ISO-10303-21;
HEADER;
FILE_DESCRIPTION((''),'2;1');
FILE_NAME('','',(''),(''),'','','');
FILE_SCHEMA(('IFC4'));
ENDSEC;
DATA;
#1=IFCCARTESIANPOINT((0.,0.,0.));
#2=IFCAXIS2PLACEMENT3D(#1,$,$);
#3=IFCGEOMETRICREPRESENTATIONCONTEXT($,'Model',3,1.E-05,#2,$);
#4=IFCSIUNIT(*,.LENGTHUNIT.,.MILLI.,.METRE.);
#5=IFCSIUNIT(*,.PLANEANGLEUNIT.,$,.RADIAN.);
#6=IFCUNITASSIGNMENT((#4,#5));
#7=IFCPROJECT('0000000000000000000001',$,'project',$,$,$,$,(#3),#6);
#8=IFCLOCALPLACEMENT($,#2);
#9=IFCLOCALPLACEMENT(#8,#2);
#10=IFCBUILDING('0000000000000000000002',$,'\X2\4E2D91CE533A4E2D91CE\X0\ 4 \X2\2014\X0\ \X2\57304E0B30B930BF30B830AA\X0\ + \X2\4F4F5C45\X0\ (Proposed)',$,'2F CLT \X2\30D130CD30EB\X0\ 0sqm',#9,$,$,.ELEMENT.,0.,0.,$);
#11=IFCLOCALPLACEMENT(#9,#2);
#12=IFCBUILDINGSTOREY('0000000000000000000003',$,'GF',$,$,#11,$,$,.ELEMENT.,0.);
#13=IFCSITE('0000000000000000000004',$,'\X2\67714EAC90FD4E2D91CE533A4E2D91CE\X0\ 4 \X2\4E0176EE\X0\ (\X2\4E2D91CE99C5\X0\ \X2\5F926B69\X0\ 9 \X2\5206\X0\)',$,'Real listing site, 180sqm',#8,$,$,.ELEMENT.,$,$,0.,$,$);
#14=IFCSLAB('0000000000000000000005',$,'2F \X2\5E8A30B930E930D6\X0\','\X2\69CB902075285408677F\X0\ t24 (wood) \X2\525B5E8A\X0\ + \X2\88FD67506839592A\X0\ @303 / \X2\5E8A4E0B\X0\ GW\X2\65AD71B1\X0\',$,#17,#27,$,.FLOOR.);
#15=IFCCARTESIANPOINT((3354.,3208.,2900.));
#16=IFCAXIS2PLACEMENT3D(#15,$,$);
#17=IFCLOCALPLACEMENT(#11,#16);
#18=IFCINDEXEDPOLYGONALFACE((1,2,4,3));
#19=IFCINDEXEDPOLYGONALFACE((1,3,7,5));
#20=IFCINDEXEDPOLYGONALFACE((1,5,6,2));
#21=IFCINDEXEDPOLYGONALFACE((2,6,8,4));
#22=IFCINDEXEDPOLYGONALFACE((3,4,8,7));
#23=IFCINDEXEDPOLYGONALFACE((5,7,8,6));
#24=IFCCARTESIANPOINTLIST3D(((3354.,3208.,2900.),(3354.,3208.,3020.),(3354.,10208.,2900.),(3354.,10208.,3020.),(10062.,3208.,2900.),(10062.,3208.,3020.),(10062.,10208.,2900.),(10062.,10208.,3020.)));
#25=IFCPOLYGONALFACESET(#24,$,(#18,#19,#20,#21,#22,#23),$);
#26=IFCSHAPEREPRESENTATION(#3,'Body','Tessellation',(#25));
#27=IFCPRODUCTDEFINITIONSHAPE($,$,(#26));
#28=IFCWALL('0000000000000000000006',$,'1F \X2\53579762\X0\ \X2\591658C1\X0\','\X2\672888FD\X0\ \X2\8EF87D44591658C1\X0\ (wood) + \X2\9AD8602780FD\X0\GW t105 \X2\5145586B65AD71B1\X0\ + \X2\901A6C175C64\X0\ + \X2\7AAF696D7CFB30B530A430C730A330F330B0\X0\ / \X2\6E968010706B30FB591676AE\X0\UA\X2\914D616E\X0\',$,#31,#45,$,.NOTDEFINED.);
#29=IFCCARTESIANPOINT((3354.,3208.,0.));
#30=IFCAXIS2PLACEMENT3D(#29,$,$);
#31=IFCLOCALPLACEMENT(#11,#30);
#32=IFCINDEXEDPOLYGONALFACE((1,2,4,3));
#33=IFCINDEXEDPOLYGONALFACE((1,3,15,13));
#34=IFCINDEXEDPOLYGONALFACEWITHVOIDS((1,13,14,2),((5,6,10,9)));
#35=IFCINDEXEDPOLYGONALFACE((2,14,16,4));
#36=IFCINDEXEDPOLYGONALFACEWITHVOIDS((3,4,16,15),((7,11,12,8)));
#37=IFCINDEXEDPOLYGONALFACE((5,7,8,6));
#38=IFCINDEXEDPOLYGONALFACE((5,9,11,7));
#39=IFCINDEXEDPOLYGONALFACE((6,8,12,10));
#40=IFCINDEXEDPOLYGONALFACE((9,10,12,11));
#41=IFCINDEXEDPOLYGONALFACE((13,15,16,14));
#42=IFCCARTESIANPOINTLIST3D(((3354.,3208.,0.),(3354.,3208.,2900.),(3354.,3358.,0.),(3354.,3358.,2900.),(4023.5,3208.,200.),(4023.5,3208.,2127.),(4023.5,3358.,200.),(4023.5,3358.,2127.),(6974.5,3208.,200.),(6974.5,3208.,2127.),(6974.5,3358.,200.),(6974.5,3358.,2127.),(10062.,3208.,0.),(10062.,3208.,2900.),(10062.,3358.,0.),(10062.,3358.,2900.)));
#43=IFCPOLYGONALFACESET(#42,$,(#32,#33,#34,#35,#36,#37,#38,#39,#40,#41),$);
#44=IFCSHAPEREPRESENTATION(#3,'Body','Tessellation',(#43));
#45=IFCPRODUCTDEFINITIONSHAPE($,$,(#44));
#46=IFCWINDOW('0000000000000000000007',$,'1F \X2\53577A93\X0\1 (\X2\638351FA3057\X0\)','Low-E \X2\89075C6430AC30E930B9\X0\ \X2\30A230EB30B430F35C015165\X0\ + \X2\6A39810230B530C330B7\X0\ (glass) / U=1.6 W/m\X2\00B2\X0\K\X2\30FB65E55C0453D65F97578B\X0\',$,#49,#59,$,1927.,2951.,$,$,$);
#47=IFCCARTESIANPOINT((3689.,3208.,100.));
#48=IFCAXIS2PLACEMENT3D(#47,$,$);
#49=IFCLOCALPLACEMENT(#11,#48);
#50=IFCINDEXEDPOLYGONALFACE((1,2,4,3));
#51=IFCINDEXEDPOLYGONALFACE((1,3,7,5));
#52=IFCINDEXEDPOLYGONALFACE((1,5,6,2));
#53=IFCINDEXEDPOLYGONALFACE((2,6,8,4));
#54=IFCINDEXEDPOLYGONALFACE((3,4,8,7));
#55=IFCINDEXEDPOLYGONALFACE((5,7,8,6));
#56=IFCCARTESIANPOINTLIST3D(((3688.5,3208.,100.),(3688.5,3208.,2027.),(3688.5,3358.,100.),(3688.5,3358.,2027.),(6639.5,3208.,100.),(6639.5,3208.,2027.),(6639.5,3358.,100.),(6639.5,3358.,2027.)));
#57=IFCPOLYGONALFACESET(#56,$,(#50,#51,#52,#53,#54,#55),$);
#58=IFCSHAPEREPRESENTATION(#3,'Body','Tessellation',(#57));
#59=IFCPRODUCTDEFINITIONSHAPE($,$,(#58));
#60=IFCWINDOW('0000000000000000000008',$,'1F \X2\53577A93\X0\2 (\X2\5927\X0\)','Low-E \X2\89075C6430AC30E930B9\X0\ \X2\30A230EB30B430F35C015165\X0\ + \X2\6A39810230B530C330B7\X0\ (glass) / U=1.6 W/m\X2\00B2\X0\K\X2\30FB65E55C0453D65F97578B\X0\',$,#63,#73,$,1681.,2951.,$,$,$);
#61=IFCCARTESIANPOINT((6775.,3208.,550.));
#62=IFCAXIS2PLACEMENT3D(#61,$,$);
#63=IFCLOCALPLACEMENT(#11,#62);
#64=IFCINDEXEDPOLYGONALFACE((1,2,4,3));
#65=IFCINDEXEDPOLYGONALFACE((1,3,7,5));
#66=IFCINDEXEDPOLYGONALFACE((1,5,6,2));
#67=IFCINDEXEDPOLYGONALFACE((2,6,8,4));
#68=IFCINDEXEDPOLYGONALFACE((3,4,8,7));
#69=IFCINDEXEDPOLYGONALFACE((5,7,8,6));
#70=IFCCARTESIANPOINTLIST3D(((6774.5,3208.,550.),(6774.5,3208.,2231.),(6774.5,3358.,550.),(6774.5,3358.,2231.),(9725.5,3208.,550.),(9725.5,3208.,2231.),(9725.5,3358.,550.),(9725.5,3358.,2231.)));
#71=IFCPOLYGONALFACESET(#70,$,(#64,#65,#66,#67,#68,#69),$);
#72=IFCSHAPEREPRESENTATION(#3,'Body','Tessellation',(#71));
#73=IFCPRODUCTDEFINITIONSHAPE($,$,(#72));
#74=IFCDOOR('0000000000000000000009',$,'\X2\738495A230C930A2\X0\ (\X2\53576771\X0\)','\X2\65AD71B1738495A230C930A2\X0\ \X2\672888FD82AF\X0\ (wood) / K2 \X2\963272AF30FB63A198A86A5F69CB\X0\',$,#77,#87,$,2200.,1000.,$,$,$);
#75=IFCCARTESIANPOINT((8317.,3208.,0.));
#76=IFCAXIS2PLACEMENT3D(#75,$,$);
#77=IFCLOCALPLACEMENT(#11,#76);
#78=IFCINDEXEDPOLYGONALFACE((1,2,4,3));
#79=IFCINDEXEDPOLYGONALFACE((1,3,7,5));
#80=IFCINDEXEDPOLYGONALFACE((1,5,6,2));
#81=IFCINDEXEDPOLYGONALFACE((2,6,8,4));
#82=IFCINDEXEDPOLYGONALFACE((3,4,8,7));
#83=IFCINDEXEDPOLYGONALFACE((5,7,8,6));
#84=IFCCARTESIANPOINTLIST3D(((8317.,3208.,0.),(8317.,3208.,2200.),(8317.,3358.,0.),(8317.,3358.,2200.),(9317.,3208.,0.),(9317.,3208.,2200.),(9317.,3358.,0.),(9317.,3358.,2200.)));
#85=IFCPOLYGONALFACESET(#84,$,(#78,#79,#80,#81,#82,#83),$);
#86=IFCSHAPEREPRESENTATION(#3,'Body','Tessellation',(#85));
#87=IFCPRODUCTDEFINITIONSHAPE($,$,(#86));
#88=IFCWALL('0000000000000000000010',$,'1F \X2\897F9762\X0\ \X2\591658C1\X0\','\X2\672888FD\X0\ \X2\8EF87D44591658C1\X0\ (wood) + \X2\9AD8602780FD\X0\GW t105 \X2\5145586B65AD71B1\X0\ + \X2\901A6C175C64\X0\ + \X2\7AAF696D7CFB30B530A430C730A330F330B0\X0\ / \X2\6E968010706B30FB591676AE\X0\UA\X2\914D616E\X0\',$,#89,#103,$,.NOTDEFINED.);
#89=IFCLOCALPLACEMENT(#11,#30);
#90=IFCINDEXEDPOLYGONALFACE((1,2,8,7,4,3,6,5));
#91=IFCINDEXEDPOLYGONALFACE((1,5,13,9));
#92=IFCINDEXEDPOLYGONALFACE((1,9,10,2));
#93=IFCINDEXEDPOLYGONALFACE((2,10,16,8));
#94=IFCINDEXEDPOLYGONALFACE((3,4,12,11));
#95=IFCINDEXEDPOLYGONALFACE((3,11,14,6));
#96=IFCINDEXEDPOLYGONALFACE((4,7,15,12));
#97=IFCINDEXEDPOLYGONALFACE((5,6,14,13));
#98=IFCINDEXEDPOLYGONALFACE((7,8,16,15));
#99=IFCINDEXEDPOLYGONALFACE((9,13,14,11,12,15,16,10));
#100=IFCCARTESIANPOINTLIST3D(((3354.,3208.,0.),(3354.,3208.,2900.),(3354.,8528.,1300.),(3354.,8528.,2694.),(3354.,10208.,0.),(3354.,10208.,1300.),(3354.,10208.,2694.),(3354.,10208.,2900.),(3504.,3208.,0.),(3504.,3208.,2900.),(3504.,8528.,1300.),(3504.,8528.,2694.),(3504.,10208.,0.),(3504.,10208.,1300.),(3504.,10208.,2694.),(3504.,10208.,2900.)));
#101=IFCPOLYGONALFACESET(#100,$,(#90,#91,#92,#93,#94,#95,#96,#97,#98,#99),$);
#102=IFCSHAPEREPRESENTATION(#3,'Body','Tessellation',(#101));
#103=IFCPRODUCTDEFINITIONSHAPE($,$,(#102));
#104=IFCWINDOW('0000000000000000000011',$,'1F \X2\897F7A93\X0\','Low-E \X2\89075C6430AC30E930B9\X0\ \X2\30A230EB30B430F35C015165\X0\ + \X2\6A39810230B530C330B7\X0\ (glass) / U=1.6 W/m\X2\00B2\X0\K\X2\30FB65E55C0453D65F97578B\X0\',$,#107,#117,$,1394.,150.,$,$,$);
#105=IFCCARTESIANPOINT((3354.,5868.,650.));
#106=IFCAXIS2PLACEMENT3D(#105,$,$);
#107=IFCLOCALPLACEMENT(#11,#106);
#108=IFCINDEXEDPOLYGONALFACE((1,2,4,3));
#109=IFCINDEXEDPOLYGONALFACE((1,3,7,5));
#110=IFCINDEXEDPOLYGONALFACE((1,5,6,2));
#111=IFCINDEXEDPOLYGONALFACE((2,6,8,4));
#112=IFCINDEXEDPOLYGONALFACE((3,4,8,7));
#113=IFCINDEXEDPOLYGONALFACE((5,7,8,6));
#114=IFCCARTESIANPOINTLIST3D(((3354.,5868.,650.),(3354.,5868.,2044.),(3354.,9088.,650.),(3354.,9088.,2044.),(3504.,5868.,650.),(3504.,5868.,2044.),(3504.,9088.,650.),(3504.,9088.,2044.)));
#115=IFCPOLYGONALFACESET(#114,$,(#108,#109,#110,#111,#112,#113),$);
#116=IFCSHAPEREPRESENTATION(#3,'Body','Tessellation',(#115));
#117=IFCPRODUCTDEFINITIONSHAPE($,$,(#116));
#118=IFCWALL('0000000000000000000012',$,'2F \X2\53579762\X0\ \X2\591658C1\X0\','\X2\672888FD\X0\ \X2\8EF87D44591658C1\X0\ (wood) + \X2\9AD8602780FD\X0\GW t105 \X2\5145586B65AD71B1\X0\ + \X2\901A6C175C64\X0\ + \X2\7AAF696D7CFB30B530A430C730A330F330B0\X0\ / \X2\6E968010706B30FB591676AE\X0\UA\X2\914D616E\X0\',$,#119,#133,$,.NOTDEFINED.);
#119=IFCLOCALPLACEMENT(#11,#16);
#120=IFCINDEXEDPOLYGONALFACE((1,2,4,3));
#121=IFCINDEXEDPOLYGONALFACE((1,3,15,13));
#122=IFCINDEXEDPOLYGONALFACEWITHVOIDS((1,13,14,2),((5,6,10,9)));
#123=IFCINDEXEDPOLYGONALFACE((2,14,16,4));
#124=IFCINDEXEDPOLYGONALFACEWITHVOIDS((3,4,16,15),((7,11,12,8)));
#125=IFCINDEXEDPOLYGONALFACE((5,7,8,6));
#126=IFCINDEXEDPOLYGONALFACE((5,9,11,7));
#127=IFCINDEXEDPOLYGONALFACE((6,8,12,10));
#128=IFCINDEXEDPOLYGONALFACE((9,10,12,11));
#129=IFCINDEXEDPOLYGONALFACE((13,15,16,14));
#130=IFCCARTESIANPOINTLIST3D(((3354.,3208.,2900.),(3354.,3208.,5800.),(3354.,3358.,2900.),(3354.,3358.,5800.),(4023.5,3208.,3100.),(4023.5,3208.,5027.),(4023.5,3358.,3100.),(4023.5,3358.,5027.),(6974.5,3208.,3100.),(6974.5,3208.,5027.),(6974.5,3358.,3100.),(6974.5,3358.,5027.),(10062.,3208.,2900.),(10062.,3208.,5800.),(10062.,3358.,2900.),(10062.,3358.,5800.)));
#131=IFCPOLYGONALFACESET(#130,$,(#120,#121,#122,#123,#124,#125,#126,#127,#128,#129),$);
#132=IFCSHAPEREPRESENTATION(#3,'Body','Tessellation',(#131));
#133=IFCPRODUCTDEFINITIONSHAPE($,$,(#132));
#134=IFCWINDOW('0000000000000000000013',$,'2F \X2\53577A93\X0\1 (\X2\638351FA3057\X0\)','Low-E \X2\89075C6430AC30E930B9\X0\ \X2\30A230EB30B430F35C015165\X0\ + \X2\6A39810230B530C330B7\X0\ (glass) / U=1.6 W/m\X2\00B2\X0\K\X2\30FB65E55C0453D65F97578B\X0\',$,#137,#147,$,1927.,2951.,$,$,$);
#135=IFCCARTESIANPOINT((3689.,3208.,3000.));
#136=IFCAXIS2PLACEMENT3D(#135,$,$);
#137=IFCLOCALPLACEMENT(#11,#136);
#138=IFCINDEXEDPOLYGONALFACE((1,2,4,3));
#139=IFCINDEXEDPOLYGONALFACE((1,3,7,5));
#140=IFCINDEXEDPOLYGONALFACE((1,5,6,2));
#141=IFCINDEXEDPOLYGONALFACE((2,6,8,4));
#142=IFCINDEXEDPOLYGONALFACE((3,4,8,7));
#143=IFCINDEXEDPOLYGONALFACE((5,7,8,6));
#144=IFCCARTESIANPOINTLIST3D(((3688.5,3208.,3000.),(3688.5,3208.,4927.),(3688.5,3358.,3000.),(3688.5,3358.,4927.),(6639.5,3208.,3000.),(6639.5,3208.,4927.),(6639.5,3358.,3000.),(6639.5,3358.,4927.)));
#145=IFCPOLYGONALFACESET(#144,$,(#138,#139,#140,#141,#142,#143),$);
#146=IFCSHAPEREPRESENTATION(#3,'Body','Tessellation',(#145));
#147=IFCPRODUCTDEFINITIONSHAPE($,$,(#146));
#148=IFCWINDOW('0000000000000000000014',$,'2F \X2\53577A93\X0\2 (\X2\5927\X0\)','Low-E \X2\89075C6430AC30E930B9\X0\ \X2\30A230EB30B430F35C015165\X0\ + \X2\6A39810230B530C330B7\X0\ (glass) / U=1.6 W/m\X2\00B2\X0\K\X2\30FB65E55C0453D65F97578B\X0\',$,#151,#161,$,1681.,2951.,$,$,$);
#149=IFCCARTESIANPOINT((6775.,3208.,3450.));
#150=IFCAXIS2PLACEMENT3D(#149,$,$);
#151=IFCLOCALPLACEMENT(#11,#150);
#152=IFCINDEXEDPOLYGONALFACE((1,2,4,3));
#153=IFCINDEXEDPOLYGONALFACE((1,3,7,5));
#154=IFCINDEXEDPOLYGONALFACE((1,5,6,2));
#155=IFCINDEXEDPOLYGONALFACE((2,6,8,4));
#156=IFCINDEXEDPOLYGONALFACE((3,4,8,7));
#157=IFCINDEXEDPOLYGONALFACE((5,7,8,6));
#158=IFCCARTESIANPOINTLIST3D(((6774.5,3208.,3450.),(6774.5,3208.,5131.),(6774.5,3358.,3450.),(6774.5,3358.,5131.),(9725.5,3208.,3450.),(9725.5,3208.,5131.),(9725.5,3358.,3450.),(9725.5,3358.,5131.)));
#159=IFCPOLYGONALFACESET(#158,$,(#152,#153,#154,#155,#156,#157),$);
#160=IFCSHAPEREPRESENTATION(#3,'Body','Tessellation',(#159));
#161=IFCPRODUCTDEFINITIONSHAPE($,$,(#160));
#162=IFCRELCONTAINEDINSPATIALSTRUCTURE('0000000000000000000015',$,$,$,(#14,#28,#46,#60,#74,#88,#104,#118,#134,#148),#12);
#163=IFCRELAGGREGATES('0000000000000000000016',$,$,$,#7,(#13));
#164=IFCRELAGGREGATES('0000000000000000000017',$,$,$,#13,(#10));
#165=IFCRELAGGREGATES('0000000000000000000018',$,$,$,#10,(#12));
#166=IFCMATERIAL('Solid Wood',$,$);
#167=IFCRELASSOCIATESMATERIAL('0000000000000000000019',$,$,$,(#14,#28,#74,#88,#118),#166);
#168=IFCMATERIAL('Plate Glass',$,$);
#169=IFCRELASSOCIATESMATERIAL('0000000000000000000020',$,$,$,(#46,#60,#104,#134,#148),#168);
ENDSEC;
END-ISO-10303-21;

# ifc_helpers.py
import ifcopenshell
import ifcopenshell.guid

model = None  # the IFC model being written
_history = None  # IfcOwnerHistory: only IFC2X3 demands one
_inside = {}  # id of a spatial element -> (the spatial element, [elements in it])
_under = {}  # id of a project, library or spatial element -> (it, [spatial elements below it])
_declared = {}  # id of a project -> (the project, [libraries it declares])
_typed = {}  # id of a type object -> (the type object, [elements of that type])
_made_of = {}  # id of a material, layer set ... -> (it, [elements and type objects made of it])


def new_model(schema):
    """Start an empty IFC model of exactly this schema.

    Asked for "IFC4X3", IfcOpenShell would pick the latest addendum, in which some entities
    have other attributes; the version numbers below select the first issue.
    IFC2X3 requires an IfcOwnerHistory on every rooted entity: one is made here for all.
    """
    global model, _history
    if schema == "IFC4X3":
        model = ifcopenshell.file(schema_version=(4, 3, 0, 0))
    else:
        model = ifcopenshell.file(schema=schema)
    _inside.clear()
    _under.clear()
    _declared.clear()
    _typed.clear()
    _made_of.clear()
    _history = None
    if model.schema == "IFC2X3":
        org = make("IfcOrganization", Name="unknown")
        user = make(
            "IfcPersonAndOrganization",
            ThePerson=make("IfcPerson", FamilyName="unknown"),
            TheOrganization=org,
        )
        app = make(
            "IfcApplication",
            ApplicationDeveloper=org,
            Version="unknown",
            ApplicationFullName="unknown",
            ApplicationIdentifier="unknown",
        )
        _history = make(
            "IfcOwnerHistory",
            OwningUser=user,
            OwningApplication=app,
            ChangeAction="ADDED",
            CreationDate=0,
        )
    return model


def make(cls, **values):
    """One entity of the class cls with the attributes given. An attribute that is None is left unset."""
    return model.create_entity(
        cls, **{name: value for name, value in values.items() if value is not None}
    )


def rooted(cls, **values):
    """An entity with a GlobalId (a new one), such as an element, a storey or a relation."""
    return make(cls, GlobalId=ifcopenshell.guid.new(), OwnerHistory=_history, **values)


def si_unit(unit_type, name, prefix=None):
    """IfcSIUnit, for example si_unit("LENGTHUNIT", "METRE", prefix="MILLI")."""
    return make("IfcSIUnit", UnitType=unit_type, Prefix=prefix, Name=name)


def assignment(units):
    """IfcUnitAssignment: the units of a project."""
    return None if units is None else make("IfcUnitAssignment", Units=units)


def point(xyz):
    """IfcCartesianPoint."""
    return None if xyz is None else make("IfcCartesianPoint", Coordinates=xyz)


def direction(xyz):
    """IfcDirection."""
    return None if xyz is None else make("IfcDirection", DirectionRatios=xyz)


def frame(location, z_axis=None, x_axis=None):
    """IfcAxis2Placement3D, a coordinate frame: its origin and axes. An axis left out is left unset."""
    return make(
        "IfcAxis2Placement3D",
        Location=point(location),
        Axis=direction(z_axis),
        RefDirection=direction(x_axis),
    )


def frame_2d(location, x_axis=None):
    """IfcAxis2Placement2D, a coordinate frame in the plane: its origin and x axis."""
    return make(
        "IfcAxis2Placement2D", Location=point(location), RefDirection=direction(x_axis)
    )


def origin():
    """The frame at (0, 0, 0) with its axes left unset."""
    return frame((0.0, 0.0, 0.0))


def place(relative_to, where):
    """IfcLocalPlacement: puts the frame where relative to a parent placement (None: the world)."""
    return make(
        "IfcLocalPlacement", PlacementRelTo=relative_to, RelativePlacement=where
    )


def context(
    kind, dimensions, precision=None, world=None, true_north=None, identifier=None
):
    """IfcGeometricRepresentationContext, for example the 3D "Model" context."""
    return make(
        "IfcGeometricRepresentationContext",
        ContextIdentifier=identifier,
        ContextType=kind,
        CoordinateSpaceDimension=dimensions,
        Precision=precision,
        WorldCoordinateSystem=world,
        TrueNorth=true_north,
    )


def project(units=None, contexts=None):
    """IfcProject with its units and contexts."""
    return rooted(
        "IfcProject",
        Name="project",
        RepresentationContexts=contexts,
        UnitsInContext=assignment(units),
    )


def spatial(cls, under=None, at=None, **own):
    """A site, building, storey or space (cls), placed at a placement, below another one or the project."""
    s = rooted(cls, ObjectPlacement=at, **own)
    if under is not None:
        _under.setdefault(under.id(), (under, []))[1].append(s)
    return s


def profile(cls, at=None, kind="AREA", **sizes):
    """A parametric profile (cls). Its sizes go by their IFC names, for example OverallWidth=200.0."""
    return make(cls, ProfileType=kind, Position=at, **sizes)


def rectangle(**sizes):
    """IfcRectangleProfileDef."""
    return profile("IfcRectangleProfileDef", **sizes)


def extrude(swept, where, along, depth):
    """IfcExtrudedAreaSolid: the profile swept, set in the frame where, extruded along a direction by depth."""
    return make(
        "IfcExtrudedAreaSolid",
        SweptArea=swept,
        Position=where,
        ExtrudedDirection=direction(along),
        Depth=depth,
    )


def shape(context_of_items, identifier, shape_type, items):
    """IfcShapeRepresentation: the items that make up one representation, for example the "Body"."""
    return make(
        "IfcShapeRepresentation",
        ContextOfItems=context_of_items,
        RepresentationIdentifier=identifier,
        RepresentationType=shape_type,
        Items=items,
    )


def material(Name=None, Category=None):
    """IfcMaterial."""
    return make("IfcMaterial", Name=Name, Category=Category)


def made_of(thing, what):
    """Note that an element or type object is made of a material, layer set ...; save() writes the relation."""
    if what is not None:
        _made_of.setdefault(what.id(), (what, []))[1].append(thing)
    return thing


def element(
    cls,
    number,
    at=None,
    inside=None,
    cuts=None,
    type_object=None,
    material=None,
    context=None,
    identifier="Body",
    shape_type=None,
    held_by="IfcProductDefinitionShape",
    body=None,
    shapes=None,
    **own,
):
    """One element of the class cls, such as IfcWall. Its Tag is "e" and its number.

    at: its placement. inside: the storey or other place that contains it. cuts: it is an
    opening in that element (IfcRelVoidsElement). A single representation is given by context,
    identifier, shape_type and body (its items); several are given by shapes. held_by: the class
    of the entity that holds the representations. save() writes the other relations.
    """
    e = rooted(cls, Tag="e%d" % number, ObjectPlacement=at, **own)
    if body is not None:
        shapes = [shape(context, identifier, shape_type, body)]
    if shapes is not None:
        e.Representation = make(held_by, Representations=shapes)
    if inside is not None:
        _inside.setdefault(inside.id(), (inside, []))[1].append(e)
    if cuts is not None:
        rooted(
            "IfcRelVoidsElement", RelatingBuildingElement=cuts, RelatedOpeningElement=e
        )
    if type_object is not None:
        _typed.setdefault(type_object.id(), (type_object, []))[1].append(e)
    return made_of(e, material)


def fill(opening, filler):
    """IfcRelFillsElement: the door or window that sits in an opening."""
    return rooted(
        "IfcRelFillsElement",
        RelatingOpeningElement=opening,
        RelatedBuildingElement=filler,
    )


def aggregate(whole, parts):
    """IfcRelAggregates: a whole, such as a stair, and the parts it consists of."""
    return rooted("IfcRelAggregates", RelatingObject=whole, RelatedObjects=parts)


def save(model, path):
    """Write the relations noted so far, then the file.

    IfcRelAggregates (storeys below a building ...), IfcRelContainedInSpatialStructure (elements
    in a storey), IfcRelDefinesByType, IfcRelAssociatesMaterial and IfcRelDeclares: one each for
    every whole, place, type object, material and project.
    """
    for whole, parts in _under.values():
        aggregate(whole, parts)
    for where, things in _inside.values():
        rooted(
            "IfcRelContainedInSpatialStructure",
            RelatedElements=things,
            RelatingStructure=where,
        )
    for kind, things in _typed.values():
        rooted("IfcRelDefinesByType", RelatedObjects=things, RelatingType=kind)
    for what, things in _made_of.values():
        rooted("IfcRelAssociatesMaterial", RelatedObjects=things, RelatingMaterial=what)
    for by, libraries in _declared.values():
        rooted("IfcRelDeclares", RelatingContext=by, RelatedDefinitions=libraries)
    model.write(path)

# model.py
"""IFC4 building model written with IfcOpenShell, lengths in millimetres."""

from ifc_helpers import new_model, si_unit, frame, frame_2d, origin, place, context, project, spatial, rectangle, extrude, material, element, fill, save


model = new_model("IFC4")

# Units and contexts
model_context = context("Model", 3, precision=1e-05, world=origin())
ifc_project = project(units=[si_unit("LENGTHUNIT", "METRE", prefix="MILLI"), si_unit("PLANEANGLEUNIT", "RADIAN")], contexts=[model_context])

# Site, building, storey
site_placement = place(None, origin())
site = spatial("IfcSite", under=ifc_project, at=site_placement, Name="東京都中野区中野 4 丁目 (中野駅 徒歩 9 分)", ObjectType="Real listing site, 180sqm", CompositionType="ELEMENT", RefElevation=0.0)
building_placement = place(site_placement, origin())
building = spatial("IfcBuilding", under=site, at=building_placement, Name="中野区中野 4 — 地下スタジオ + 住居 (Proposed)", ObjectType="2F CLT パネル 0sqm", CompositionType="ELEMENT", ElevationOfRefHeight=0.0, ElevationOfTerrain=0.0)
storey_placement = place(building_placement, origin())
storey = spatial("IfcBuildingStorey", under=building, at=storey_placement, Name="GF", CompositionType="ELEMENT", Elevation=0.0)

# Slab
ifc_material_1 = material(Name="Solid Wood")
slab_1_placement = place(storey_placement, frame((3354.0, 3208.0, 2900.0)))
element("IfcSlab", 1, at=slab_1_placement, inside=storey, material=ifc_material_1, Name="2F 床スラブ", Description="構造用合板 t24 (wood) 剛床 + 製材根太 @303 / 床下 GW断熱", PredefinedType="FLOOR", context=model_context, shape_type="SweptSolid", body=[
    extrude(rectangle(XDim=6708.0, YDim=7000.0, at=frame_2d((3354.0, 3500.0))), frame((3354.0, 3208.0, 2900.0)), (0.0, 0.0, 1.0), 120.0),
])

# Wall, openings, windows, door
wall_1_placement = place(storey_placement, frame((3354.0, 3208.0, 0.0)))
wall_1 = element("IfcWall", 2, at=wall_1_placement, inside=storey, material=ifc_material_1, Name="1F 南面 外壁", Description="木製 軸組外壁 (wood) + 高性能GW t105 充填断熱 + 通気層 + 窯業系サイディング / 準耐火・外皮UA配慮", PredefinedType="NOTDEFINED", context=model_context, shape_type="SweptSolid", body=[
    extrude(rectangle(XDim=6708.0, YDim=150.0, at=frame_2d((3354.0, 75.0))), frame((3354.0, 3208.0, 0.0)), (0.0, 0.0, 1.0), 2900.0),
])
opening_1_placement = place(storey_placement, frame((3689.0, 3208.0, 100.0)))
opening_1 = element("IfcOpeningElement", 3, at=opening_1_placement, cuts=wall_1, PredefinedType="NOTDEFINED", context=model_context, shape_type="SweptSolid", body=[
    extrude(rectangle(XDim=2951.0, YDim=150.0, at=frame_2d((1475.0, 75.0))), frame((3689.0, 3208.0, 100.0)), (0.0, 0.0, 1.0), 1927.0),
])
opening_2_placement = place(storey_placement, frame((6775.0, 3208.0, 550.0)))
opening_2 = element("IfcOpeningElement", 4, at=opening_2_placement, cuts=wall_1, PredefinedType="NOTDEFINED", context=model_context, shape_type="SweptSolid", body=[
    extrude(rectangle(XDim=2951.0, YDim=150.0, at=frame_2d((1475.0, 75.0))), frame((6775.0, 3208.0, 550.0)), (0.0, 0.0, 1.0), 1681.0),
])
opening_3_placement = place(storey_placement, frame((8317.0, 3208.0, 0.0)))
opening_3 = element("IfcOpeningElement", 5, at=opening_3_placement, cuts=wall_1, PredefinedType="NOTDEFINED", context=model_context, shape_type="SweptSolid", body=[
    extrude(rectangle(XDim=1000.0, YDim=150.0, at=frame_2d((500.0, 75.0))), frame((8317.0, 3208.0, 0.0)), (0.0, 0.0, 1.0), 2200.0),
])
ifc_material_2 = material(Name="Plate Glass")
window_1_placement = place(storey_placement, frame((3689.0, 3208.0, 100.0)))
window_1 = element("IfcWindow", 6, at=window_1_placement, inside=storey, material=ifc_material_2, Name="1F 南窓1 (掃出し)", Description="Low-E 複層ガラス アルゴン封入 + 樹脂サッシ (glass) / U=1.6 W/m²K・日射取得型", OverallHeight=1927.0, OverallWidth=2951.0, context=model_context, shape_type="SweptSolid", body=[
    extrude(rectangle(XDim=2951.0, YDim=150.0, at=frame_2d((1475.0, 75.0))), frame((3689.0, 3208.0, 100.0)), (0.0, 0.0, 1.0), 1927.0),
])
fill(opening_1, window_1)
window_2_placement = place(storey_placement, frame((6775.0, 3208.0, 550.0)))
window_2 = element("IfcWindow", 7, at=window_2_placement, inside=storey, material=ifc_material_2, Name="1F 南窓2 (大)", Description="Low-E 複層ガラス アルゴン封入 + 樹脂サッシ (glass) / U=1.6 W/m²K・日射取得型", OverallHeight=1681.0, OverallWidth=2951.0, context=model_context, shape_type="SweptSolid", body=[
    extrude(rectangle(XDim=2951.0, YDim=150.0, at=frame_2d((1475.0, 75.0))), frame((6775.0, 3208.0, 550.0)), (0.0, 0.0, 1.0), 1681.0),
])
fill(opening_2, window_2)
door_placement = place(storey_placement, frame((8317.0, 3208.0, 0.0)))
door = element("IfcDoor", 8, at=door_placement, inside=storey, material=ifc_material_1, Name="玄関ドア (南東)", Description="断熱玄関ドア 木製芯 (wood) / K2 防犯・採風機構", OverallHeight=2200.0, OverallWidth=1000.0, context=model_context, shape_type="SweptSolid", body=[
    extrude(rectangle(XDim=1000.0, YDim=150.0, at=frame_2d((500.0, 75.0))), frame((8317.0, 3208.0, 0.0)), (0.0, 0.0, 1.0), 2200.0),
])
fill(opening_3, door)

# Wall, opening, window
wall_2_placement = place(storey_placement, frame((3354.0, 3208.0, 0.0)))
wall_2 = element("IfcWall", 9, at=wall_2_placement, inside=storey, material=ifc_material_1, Name="1F 西面 外壁", Description="木製 軸組外壁 (wood) + 高性能GW t105 充填断熱 + 通気層 + 窯業系サイディング / 準耐火・外皮UA配慮", PredefinedType="NOTDEFINED", context=model_context, shape_type="SweptSolid", body=[
    extrude(rectangle(XDim=150.0, YDim=7000.0, at=frame_2d((75.0, 3500.0))), frame((3354.0, 3208.0, 0.0)), (0.0, 0.0, 1.0), 2900.0),
])
opening_4_placement = place(storey_placement, frame((3354.0, 5868.0, 650.0)))
opening_4 = element("IfcOpeningElement", 10, at=opening_4_placement, cuts=wall_2, PredefinedType="NOTDEFINED", context=model_context, shape_type="SweptSolid", body=[
    extrude(rectangle(XDim=150.0, YDim=3220.0, at=frame_2d((75.0, 1610.0))), frame((3354.0, 5868.0, 650.0)), (0.0, 0.0, 1.0), 1394.0),
])
window_3_placement = place(storey_placement, frame((3354.0, 5868.0, 650.0)))
window_3 = element("IfcWindow", 11, at=window_3_placement, inside=storey, material=ifc_material_2, Name="1F 西窓", Description="Low-E 複層ガラス アルゴン封入 + 樹脂サッシ (glass) / U=1.6 W/m²K・日射取得型", OverallHeight=1394.0, OverallWidth=150.0, context=model_context, shape_type="SweptSolid", body=[
    extrude(rectangle(XDim=150.0, YDim=3220.0, at=frame_2d((75.0, 1610.0))), frame((3354.0, 5868.0, 650.0)), (0.0, 0.0, 1.0), 1394.0),
])
fill(opening_4, window_3)

# Wall, openings, windows
wall_3_placement = place(storey_placement, frame((3354.0, 3208.0, 2900.0)))
wall_3 = element("IfcWall", 12, at=wall_3_placement, inside=storey, material=ifc_material_1, Name="2F 南面 外壁", Description="木製 軸組外壁 (wood) + 高性能GW t105 充填断熱 + 通気層 + 窯業系サイディング / 準耐火・外皮UA配慮", PredefinedType="NOTDEFINED", context=model_context, shape_type="SweptSolid", body=[
    extrude(rectangle(XDim=6708.0, YDim=150.0, at=frame_2d((3354.0, 75.0))), frame((3354.0, 3208.0, 2900.0)), (0.0, 0.0, 1.0), 2900.0),
])
opening_5_placement = place(storey_placement, frame((3689.0, 3208.0, 3000.0)))
opening_5 = element("IfcOpeningElement", 13, at=opening_5_placement, cuts=wall_3, PredefinedType="NOTDEFINED", context=model_context, shape_type="SweptSolid", body=[
    extrude(rectangle(XDim=2951.0, YDim=150.0, at=frame_2d((1475.0, 75.0))), frame((3689.0, 3208.0, 3000.0)), (0.0, 0.0, 1.0), 1927.0),
])
opening_6_placement = place(storey_placement, frame((6775.0, 3208.0, 3450.0)))
opening_6 = element("IfcOpeningElement", 14, at=opening_6_placement, cuts=wall_3, PredefinedType="NOTDEFINED", context=model_context, shape_type="SweptSolid", body=[
    extrude(rectangle(XDim=2951.0, YDim=150.0, at=frame_2d((1475.0, 75.0))), frame((6775.0, 3208.0, 3450.0)), (0.0, 0.0, 1.0), 1681.0),
])
window_4_placement = place(storey_placement, frame((3689.0, 3208.0, 3000.0)))
window_4 = element("IfcWindow", 15, at=window_4_placement, inside=storey, material=ifc_material_2, Name="2F 南窓1 (掃出し)", Description="Low-E 複層ガラス アルゴン封入 + 樹脂サッシ (glass) / U=1.6 W/m²K・日射取得型", OverallHeight=1927.0, OverallWidth=2951.0, context=model_context, shape_type="SweptSolid", body=[
    extrude(rectangle(XDim=2951.0, YDim=150.0, at=frame_2d((1475.0, 75.0))), frame((3689.0, 3208.0, 3000.0)), (0.0, 0.0, 1.0), 1927.0),
])
fill(opening_5, window_4)
window_5_placement = place(storey_placement, frame((6775.0, 3208.0, 3450.0)))
window_5 = element("IfcWindow", 16, at=window_5_placement, inside=storey, material=ifc_material_2, Name="2F 南窓2 (大)", Description="Low-E 複層ガラス アルゴン封入 + 樹脂サッシ (glass) / U=1.6 W/m²K・日射取得型", OverallHeight=1681.0, OverallWidth=2951.0, context=model_context, shape_type="SweptSolid", body=[
    extrude(rectangle(XDim=2951.0, YDim=150.0, at=frame_2d((1475.0, 75.0))), frame((6775.0, 3208.0, 3450.0)), (0.0, 0.0, 1.0), 1681.0),
])
fill(opening_6, window_5)

save(model, "model.ifc")
